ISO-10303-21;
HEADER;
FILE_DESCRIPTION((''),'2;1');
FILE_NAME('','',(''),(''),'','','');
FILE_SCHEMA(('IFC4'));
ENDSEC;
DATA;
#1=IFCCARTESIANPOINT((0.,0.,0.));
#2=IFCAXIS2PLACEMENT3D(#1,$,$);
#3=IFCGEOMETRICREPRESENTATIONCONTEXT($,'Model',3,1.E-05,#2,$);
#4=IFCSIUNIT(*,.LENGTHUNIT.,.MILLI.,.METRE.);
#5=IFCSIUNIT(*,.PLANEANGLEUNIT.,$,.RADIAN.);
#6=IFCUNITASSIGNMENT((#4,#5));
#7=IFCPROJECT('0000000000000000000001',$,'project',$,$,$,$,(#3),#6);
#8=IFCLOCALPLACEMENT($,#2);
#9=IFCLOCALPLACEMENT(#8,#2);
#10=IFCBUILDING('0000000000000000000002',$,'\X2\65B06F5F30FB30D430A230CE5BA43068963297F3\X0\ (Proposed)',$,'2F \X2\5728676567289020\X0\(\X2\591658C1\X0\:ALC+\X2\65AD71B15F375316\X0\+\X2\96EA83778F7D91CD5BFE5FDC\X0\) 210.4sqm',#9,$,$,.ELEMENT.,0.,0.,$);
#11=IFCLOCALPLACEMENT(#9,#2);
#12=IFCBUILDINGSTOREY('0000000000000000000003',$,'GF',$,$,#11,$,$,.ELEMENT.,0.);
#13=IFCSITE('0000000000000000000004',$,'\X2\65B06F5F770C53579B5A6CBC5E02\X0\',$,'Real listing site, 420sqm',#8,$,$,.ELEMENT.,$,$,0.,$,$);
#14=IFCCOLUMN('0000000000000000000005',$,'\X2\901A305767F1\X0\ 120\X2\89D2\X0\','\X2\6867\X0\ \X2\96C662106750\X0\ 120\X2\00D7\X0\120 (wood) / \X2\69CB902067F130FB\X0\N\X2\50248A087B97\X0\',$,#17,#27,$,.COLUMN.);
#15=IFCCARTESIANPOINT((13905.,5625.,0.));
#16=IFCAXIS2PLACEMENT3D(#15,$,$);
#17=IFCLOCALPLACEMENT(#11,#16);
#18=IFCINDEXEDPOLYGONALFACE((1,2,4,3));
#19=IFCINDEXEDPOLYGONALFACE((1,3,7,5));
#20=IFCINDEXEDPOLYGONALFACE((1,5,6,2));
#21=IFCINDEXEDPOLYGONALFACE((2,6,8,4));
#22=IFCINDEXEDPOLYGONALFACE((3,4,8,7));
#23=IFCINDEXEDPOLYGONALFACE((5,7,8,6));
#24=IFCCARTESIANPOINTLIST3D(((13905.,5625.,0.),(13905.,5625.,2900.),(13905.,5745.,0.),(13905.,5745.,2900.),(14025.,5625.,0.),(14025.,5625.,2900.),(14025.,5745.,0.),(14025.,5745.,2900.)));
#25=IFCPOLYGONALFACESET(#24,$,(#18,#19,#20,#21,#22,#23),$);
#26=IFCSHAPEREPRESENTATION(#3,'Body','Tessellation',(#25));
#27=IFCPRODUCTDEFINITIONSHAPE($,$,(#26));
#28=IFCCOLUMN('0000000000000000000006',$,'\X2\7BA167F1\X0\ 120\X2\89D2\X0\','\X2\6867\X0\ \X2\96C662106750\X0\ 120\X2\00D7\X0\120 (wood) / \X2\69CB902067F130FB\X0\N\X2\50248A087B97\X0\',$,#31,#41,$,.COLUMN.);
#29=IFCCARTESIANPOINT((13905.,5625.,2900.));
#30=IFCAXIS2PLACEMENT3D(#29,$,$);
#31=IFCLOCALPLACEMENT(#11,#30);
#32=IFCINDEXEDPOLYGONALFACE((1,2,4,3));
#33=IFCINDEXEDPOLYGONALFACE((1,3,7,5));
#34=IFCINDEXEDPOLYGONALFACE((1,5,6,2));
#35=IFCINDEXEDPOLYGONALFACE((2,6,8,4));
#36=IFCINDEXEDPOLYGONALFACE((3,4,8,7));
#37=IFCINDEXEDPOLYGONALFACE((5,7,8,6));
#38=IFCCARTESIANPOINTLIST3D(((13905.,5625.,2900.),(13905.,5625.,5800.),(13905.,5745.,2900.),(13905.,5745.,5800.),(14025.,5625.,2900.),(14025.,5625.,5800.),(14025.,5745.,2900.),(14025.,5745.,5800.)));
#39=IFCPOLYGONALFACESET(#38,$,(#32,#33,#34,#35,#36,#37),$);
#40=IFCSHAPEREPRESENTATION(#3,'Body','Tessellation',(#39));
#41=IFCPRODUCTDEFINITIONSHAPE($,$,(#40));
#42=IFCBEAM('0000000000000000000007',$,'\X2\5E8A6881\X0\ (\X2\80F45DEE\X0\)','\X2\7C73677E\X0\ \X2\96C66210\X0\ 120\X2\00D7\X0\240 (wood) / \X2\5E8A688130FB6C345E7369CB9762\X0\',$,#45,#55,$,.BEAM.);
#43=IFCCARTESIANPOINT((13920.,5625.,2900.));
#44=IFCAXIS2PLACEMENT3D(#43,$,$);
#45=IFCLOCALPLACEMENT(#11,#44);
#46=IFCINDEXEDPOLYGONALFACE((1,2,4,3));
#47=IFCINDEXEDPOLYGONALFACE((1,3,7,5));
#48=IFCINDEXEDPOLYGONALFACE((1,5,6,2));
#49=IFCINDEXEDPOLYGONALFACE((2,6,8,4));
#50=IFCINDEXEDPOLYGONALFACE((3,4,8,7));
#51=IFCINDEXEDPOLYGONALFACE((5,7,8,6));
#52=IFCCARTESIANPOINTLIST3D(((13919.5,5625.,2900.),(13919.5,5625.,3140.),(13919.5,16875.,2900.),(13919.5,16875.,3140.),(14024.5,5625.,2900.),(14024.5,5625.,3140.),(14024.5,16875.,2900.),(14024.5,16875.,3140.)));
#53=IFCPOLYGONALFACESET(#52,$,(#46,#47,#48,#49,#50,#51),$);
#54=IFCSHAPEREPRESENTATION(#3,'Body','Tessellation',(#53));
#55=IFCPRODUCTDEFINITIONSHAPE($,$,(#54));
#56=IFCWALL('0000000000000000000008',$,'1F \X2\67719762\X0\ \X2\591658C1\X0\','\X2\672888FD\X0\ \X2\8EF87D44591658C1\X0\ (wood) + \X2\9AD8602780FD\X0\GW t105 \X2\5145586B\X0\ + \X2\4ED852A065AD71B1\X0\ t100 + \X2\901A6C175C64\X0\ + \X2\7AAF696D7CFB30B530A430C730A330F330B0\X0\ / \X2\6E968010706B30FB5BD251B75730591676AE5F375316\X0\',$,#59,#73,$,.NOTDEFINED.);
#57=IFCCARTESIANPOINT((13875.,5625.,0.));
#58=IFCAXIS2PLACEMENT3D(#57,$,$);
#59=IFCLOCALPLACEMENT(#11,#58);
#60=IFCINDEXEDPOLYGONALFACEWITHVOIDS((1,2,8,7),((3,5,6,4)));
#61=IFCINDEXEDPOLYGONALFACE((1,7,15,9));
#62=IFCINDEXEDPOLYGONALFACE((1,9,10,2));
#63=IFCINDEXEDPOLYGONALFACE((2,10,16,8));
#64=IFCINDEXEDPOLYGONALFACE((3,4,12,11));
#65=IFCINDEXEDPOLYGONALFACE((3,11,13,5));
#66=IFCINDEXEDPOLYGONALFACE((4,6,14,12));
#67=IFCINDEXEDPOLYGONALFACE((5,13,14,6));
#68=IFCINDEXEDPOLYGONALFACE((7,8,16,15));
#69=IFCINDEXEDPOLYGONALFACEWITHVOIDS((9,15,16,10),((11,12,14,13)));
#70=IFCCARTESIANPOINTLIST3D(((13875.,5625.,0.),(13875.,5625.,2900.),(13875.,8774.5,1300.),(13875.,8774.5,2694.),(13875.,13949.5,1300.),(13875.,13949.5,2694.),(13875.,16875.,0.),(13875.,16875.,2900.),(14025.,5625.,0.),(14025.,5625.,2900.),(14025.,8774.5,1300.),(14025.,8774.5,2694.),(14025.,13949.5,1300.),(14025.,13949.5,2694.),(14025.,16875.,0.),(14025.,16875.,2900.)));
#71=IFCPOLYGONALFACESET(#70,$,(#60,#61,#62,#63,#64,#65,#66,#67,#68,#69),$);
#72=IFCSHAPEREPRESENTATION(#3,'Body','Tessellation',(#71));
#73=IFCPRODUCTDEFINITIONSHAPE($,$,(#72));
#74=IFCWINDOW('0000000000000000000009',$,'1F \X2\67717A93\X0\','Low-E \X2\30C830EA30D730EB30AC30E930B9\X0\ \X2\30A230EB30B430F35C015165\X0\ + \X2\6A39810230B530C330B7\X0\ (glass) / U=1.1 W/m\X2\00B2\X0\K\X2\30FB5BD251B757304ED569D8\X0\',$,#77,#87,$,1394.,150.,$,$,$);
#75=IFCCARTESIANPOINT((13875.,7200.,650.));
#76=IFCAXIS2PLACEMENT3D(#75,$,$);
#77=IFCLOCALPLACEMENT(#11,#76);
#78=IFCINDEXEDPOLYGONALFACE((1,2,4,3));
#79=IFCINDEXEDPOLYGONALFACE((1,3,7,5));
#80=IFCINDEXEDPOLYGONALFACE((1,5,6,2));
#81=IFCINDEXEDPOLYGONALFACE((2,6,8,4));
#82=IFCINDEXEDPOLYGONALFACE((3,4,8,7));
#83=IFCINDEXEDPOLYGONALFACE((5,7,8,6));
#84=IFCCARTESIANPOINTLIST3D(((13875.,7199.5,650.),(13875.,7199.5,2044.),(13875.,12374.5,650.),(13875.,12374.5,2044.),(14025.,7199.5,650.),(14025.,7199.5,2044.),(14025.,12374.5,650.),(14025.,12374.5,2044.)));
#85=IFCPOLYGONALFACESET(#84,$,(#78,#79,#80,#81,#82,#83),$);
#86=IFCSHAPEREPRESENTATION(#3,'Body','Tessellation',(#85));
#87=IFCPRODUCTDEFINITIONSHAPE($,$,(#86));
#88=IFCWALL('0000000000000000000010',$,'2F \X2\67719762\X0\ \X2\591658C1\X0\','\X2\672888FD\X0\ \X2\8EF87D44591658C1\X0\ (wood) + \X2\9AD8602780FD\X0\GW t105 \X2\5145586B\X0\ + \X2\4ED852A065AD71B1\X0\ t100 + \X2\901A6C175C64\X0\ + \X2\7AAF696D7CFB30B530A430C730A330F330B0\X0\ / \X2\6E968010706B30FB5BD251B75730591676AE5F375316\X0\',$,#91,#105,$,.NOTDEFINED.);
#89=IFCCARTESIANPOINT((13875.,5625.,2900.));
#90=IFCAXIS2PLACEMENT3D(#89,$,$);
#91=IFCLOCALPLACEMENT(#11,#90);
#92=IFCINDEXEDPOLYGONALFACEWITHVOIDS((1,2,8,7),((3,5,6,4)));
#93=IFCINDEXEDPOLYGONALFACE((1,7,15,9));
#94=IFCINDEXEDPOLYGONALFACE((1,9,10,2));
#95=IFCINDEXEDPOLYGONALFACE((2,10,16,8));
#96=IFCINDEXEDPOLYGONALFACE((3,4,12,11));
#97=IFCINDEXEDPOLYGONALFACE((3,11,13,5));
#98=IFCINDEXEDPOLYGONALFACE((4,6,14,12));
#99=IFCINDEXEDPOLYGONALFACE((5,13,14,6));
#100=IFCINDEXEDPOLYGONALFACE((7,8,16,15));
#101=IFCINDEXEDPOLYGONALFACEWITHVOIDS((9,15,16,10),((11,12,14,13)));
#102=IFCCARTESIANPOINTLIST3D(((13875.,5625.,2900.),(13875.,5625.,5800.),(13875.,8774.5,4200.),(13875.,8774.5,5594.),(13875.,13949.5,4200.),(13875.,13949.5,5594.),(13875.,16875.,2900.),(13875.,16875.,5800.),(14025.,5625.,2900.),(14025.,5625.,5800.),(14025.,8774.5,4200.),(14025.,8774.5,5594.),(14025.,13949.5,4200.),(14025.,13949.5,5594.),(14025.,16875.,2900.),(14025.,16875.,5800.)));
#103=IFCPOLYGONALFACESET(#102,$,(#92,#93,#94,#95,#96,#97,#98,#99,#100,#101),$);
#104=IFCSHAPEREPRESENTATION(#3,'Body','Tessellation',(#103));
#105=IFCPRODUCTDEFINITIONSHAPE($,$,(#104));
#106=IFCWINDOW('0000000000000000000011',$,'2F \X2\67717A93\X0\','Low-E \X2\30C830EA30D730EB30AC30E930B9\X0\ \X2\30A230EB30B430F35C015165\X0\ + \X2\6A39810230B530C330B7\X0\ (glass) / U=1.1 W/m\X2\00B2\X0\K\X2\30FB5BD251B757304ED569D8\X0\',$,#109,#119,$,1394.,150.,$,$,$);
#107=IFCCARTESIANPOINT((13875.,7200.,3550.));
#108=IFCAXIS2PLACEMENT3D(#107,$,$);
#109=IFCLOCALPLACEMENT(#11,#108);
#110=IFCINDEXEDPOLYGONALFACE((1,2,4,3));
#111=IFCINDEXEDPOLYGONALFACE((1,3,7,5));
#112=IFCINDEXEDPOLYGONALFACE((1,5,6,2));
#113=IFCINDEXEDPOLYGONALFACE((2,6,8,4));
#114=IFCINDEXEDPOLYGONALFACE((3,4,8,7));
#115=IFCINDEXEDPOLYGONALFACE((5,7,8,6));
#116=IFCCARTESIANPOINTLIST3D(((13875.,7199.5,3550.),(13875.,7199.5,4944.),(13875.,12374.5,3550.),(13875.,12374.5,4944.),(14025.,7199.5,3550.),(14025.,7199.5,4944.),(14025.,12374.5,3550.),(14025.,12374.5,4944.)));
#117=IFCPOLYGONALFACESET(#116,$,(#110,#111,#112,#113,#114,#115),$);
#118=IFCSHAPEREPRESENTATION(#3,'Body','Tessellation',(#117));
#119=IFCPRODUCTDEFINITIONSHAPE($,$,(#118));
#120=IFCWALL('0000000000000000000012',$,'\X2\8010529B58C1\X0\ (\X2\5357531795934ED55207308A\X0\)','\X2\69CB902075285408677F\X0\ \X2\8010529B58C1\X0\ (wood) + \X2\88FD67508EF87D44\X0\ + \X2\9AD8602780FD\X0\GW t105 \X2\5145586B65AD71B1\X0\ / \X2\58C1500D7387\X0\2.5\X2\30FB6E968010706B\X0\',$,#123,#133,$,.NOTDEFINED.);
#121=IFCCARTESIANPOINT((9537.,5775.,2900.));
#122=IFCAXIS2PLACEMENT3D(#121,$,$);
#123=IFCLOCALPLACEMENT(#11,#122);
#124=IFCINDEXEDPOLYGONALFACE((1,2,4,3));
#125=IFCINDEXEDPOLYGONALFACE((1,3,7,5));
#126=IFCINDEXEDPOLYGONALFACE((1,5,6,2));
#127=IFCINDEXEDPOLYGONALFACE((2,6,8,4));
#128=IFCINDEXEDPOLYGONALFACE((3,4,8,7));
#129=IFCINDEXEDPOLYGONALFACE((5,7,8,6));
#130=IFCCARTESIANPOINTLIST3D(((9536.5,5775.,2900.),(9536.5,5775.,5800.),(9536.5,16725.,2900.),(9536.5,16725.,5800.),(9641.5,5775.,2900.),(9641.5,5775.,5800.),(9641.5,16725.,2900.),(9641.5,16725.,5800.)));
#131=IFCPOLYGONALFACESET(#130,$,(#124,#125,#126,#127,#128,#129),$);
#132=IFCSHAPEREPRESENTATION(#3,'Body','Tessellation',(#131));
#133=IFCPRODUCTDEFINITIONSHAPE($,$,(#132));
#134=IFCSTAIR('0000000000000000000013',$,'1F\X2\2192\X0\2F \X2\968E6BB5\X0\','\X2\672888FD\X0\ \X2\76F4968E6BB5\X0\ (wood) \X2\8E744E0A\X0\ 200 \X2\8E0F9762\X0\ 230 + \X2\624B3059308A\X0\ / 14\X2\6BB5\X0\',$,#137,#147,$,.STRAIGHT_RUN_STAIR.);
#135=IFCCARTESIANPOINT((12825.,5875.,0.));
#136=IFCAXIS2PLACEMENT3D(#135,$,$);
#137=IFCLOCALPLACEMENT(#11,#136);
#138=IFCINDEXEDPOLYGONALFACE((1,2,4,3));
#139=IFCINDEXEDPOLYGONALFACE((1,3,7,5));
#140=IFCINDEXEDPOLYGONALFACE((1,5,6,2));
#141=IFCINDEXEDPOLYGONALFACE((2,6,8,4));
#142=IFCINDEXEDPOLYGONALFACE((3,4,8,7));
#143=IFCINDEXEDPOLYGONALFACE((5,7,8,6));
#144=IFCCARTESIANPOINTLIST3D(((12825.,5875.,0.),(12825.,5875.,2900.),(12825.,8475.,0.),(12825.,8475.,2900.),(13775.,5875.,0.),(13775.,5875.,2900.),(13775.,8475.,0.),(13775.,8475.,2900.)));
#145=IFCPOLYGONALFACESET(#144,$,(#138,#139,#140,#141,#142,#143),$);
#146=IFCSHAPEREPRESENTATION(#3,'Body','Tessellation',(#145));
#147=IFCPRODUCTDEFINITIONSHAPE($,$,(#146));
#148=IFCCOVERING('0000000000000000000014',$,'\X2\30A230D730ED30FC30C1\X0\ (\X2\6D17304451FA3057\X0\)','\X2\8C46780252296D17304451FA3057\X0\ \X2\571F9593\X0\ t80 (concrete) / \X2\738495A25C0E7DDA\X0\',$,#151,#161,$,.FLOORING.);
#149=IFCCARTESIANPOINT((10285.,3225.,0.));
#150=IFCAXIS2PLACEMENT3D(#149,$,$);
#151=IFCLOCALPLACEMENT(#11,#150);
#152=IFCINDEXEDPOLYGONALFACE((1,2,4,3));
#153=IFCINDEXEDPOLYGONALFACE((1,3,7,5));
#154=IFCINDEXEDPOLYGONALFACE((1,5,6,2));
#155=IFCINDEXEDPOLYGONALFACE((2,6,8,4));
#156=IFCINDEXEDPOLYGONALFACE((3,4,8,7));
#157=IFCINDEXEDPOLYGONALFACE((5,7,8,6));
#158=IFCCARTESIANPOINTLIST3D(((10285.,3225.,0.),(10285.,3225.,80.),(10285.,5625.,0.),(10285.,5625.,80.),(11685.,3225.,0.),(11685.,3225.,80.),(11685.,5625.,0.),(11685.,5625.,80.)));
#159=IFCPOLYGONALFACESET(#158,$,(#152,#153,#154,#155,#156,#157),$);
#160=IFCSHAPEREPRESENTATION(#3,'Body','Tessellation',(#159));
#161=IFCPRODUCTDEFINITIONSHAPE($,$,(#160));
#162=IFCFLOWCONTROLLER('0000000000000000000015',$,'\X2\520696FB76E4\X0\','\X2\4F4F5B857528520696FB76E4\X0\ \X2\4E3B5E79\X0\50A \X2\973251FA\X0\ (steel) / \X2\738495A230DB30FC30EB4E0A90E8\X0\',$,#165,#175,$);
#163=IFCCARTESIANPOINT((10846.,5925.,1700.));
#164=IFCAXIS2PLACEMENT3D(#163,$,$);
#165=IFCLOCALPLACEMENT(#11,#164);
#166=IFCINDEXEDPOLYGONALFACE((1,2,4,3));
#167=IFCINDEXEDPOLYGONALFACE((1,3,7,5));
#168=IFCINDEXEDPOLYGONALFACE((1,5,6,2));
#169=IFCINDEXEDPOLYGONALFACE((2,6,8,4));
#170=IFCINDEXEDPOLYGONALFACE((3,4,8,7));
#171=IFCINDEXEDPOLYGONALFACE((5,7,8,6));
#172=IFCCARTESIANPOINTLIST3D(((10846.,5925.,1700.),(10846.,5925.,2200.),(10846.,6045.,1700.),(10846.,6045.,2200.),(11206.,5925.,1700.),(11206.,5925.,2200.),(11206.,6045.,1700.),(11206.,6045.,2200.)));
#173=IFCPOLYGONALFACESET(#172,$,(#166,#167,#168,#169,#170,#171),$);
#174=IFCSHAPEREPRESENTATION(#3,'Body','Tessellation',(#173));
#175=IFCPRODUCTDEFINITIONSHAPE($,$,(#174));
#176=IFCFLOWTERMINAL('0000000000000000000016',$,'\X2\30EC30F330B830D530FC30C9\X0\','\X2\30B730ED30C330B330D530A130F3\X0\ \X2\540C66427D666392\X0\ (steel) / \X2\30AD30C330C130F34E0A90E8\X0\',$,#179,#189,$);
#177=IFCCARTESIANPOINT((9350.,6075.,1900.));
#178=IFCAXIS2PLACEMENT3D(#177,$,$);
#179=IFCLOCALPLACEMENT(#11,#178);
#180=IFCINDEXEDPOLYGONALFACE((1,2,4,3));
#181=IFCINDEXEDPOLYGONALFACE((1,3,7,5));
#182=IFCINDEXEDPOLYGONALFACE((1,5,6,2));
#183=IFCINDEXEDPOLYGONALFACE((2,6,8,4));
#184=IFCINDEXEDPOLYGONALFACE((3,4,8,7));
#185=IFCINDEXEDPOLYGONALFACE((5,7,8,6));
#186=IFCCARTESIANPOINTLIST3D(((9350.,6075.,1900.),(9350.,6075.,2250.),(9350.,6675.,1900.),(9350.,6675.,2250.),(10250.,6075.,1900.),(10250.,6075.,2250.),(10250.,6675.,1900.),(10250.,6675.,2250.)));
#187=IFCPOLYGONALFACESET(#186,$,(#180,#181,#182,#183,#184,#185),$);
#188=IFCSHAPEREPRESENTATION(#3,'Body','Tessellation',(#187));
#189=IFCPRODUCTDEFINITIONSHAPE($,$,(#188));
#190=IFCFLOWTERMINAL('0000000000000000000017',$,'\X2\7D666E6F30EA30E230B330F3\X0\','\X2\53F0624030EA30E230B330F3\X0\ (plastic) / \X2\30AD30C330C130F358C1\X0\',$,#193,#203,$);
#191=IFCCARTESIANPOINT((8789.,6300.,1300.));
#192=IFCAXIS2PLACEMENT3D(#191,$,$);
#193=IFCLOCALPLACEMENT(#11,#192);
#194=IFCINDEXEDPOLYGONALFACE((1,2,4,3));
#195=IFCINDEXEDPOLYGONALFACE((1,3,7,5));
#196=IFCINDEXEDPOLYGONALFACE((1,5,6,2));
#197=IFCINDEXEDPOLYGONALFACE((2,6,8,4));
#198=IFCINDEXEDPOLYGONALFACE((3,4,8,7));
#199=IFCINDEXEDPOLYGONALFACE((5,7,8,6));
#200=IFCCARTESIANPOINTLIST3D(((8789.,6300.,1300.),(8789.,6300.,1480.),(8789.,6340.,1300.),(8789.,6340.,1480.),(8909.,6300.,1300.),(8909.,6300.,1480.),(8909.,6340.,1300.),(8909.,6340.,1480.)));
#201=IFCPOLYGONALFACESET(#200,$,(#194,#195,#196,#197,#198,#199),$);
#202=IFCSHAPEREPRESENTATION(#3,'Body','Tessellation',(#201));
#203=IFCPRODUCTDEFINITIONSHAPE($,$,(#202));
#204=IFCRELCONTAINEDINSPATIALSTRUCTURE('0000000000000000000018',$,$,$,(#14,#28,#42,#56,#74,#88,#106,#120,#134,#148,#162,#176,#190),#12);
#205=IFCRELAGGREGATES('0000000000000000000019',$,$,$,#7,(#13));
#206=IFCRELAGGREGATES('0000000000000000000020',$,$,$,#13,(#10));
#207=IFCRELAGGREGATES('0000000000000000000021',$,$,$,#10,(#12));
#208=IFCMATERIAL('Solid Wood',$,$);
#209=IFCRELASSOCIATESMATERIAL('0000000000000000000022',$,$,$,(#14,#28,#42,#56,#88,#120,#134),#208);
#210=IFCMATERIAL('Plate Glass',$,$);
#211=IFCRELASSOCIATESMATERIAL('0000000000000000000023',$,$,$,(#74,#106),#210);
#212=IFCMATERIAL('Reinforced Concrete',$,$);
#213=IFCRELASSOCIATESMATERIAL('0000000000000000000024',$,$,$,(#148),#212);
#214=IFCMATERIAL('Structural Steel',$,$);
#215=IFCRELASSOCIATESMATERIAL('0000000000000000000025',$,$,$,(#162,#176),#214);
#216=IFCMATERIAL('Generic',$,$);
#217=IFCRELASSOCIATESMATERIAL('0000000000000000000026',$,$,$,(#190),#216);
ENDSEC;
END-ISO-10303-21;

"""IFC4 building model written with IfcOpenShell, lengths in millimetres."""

from ifc_helpers import new_model, si_unit, frame, frame_2d, origin, place, context, project, spatial, rectangle, extrude, material, element, fill, save


model = new_model("IFC4")

# Units and contexts
model_context = context("Model", 3, precision=1e-05, world=origin())
ifc_project = project(units=[si_unit("LENGTHUNIT", "METRE", prefix="MILLI"), si_unit("PLANEANGLEUNIT", "RADIAN")], contexts=[model_context])

# Site, building, storey
site_placement = place(None, origin())
site = spatial("IfcSite", under=ifc_project, at=site_placement, Name="新潟県南魚沼市", ObjectType="Real listing site, 420sqm", CompositionType="ELEMENT", RefElevation=0.0)
building_placement = place(site_placement, origin())
building = spatial("IfcBuilding", under=site, at=building_placement, Name="新潟・ピアノ室と防音 (Proposed)", ObjectType="2F 在来木造(外壁:ALC+断熱強化+雪荷载重対応) 210.4sqm", CompositionType="ELEMENT", ElevationOfRefHeight=0.0, ElevationOfTerrain=0.0)
storey_placement = place(building_placement, origin())
storey = spatial("IfcBuildingStorey", under=building, at=storey_placement, Name="GF", CompositionType="ELEMENT", Elevation=0.0)

# Columns
ifc_material_1 = material(Name="Solid Wood")
column_1_placement = place(storey_placement, frame((13905.0, 5625.0, 0.0)))
element("IfcColumn", 1, at=column_1_placement, inside=storey, material=ifc_material_1, Name="通し柱 120角", Description="桧 集成材 120×120 (wood) / 構造柱・N値計算", PredefinedType="COLUMN", context=model_context, shape_type="SweptSolid", body=[
    extrude(rectangle(XDim=120.0, YDim=120.0, at=frame_2d((60.0, 60.0))), frame((13905.0, 5625.0, 0.0)), (0.0, 0.0, 1.0), 2900.0),
])
column_2_placement = place(storey_placement, frame((13905.0, 5625.0, 2900.0)))
element("IfcColumn", 2, at=column_2_placement, inside=storey, material=ifc_material_1, Name="管柱 120角", Description="桧 集成材 120×120 (wood) / 構造柱・N値計算", PredefinedType="COLUMN", context=model_context, shape_type="SweptSolid", body=[
    extrude(rectangle(XDim=120.0, YDim=120.0, at=frame_2d((60.0, 60.0))), frame((13905.0, 5625.0, 2900.0)), (0.0, 0.0, 1.0), 2900.0),
])

# Beam
beam_1_placement = place(storey_placement, frame((13920.0, 5625.0, 2900.0)))
element("IfcBeam", 3, at=beam_1_placement, inside=storey, material=ifc_material_1, Name="床梁 (胴差)", Description="米松 集成 120×240 (wood) / 床梁・水平構面", PredefinedType="BEAM", context=model_context, shape_type="SweptSolid", body=[
    extrude(rectangle(XDim=105.0, YDim=11250.0, at=frame_2d((52.0, 5625.0))), frame((13920.0, 5625.0, 2900.0)), (0.0, 0.0, 1.0), 240.0),
])

# Wall, opening, window
wall_1_placement = place(storey_placement, frame((13875.0, 5625.0, 0.0)))
wall_1 = element("IfcWall", 4, at=wall_1_placement, inside=storey, material=ifc_material_1, Name="1F 東面 外壁", Description="木製 軸組外壁 (wood) + 高性能GW t105 充填 + 付加断熱 t100 + 通気層 + 窯業系サイディング / 準耐火・寒冷地外皮強化", PredefinedType="NOTDEFINED", context=model_context, shape_type="SweptSolid", body=[
    extrude(rectangle(XDim=150.0, YDim=11250.0, at=frame_2d((75.0, 5625.0))), frame((13875.0, 5625.0, 0.0)), (0.0, 0.0, 1.0), 2900.0),
])
opening_1_placement = place(storey_placement, frame((13875.0, 7200.0, 650.0)))
opening_1 = element("IfcOpeningElement", 5, at=opening_1_placement, cuts=wall_1, PredefinedType="NOTDEFINED", context=model_context, shape_type="SweptSolid", body=[
    extrude(rectangle(XDim=150.0, YDim=5175.0, at=frame_2d((75.0, 2587.0))), frame((13875.0, 7200.0, 650.0)), (0.0, 0.0, 1.0), 1394.0),
])
ifc_material_2 = material(Name="Plate Glass")
window_1_placement = place(storey_placement, frame((13875.0, 7200.0, 650.0)))
window_1 = element("IfcWindow", 6, at=window_1_placement, inside=storey, material=ifc_material_2, Name="1F 東窓", Description="Low-E トリプルガラス アルゴン封入 + 樹脂サッシ (glass) / U=1.1 W/m²K・寒冷地仕様", OverallHeight=1394.0, OverallWidth=150.0, context=model_context, shape_type="SweptSolid", body=[
    extrude(rectangle(XDim=150.0, YDim=5175.0, at=frame_2d((75.0, 2587.0))), frame((13875.0, 7200.0, 650.0)), (0.0, 0.0, 1.0), 1394.0),
])
fill(opening_1, window_1)

# Wall, opening, window
wall_2_placement = place(storey_placement, frame((13875.0, 5625.0, 2900.0)))
wall_2 = element("IfcWall", 7, at=wall_2_placement, inside=storey, material=ifc_material_1, Name="2F 東面 外壁", Description="木製 軸組外壁 (wood) + 高性能GW t105 充填 + 付加断熱 t100 + 通気層 + 窯業系サイディング / 準耐火・寒冷地外皮強化", PredefinedType="NOTDEFINED", context=model_context, shape_type="SweptSolid", body=[
    extrude(rectangle(XDim=150.0, YDim=11250.0, at=frame_2d((75.0, 5625.0))), frame((13875.0, 5625.0, 2900.0)), (0.0, 0.0, 1.0), 2900.0),
])
opening_2_placement = place(storey_placement, frame((13875.0, 7200.0, 3550.0)))
opening_2 = element("IfcOpeningElement", 8, at=opening_2_placement, cuts=wall_2, PredefinedType="NOTDEFINED", context=model_context, shape_type="SweptSolid", body=[
    extrude(rectangle(XDim=150.0, YDim=5175.0, at=frame_2d((75.0, 2587.0))), frame((13875.0, 7200.0, 3550.0)), (0.0, 0.0, 1.0), 1394.0),
])
window_2_placement = place(storey_placement, frame((13875.0, 7200.0, 3550.0)))
window_2 = element("IfcWindow", 9, at=window_2_placement, inside=storey, material=ifc_material_2, Name="2F 東窓", Description="Low-E トリプルガラス アルゴン封入 + 樹脂サッシ (glass) / U=1.1 W/m²K・寒冷地仕様", OverallHeight=1394.0, OverallWidth=150.0, context=model_context, shape_type="SweptSolid", body=[
    extrude(rectangle(XDim=150.0, YDim=5175.0, at=frame_2d((75.0, 2587.0))), frame((13875.0, 7200.0, 3550.0)), (0.0, 0.0, 1.0), 1394.0),
])
fill(opening_2, window_2)

# Wall
wall_3_placement = place(storey_placement, frame((9537.0, 5775.0, 2900.0)))
element("IfcWall", 10, at=wall_3_placement, inside=storey, material=ifc_material_1, Name="耐力壁 (南北間仕切り)", Description="構造用合板 耐力壁 (wood) + 製材軸組 + 高性能GW t105 充填断熱 / 壁倍率2.5・準耐火", PredefinedType="NOTDEFINED", context=model_context, shape_type="SweptSolid", body=[
    extrude(rectangle(XDim=105.0, YDim=10950.0, at=frame_2d((52.0, 5475.0))), frame((9537.0, 5775.0, 2900.0)), (0.0, 0.0, 1.0), 2900.0),
])

# Stair
stair_placement = place(storey_placement, frame((12825.0, 5875.0, 0.0)))
element("IfcStair", 11, at=stair_placement, inside=storey, material=ifc_material_1, Name="1F→2F 階段", Description="木製 直階段 (wood) 蹴上 200 踏面 230 + 手すり / 14段", PredefinedType="STRAIGHT_RUN_STAIR", context=model_context, shape_type="SweptSolid", body=[
    extrude(rectangle(XDim=950.0, YDim=2600.0, at=frame_2d((475.0, 1300.0))), frame((12825.0, 5875.0, 0.0)), (0.0, 0.0, 1.0), 2900.0),
])

# Covering
ifc_material_3 = material(Name="Reinforced Concrete")
covering_placement = place(storey_placement, frame((10285.0, 3225.0, 0.0)))
element("IfcCovering", 12, at=covering_placement, inside=storey, material=ifc_material_3, Name="アプローチ (洗い出し)", Description="豆砂利洗い出し 土間 t80 (concrete) / 玄関導線", PredefinedType="FLOORING", context=model_context, shape_type="SweptSolid", body=[
    extrude(rectangle(XDim=1400.0, YDim=2400.0, at=frame_2d((700.0, 1200.0))), frame((10285.0, 3225.0, 0.0)), (0.0, 0.0, 1.0), 80.0),
])

# Flow controller
ifc_material_4 = material(Name="Structural Steel")
flow_controller_placement = place(storey_placement, frame((10846.0, 5925.0, 1700.0)))
element("IfcFlowController", 13, at=flow_controller_placement, inside=storey, material=ifc_material_4, Name="分電盤", Description="住宅用分電盤 主幹50A 露出 (steel) / 玄関ホール上部", context=model_context, shape_type="SweptSolid", body=[
    extrude(rectangle(XDim=360.0, YDim=120.0, at=frame_2d((180.0, 60.0))), frame((10846.0, 5925.0, 1700.0)), (0.0, 0.0, 1.0), 500.0),
])

# Flow terminals
flow_terminal_1_placement = place(storey_placement, frame((9350.0, 6075.0, 1900.0)))
element("IfcFlowTerminal", 14, at=flow_terminal_1_placement, inside=storey, material=ifc_material_4, Name="レンジフード", Description="シロッコファン 同時給排 (steel) / キッチン上部", context=model_context, shape_type="SweptSolid", body=[
    extrude(rectangle(XDim=900.0, YDim=600.0, at=frame_2d((450.0, 300.0))), frame((9350.0, 6075.0, 1900.0)), (0.0, 0.0, 1.0), 350.0),
])
ifc_material_5 = material(Name="Generic")
flow_terminal_2_placement = place(storey_placement, frame((8789.0, 6300.0, 1300.0)))
element("IfcFlowTerminal", 15, at=flow_terminal_2_placement, inside=storey, material=ifc_material_5, Name="給湯リモコン", Description="台所リモコン (plastic) / キッチン壁", context=model_context, shape_type="SweptSolid", body=[
    extrude(rectangle(XDim=120.0, YDim=40.0, at=frame_2d((60.0, 20.0))), frame((8789.0, 6300.0, 1300.0)), (0.0, 0.0, 1.0), 180.0),
])

save(model, "model.ifc")
